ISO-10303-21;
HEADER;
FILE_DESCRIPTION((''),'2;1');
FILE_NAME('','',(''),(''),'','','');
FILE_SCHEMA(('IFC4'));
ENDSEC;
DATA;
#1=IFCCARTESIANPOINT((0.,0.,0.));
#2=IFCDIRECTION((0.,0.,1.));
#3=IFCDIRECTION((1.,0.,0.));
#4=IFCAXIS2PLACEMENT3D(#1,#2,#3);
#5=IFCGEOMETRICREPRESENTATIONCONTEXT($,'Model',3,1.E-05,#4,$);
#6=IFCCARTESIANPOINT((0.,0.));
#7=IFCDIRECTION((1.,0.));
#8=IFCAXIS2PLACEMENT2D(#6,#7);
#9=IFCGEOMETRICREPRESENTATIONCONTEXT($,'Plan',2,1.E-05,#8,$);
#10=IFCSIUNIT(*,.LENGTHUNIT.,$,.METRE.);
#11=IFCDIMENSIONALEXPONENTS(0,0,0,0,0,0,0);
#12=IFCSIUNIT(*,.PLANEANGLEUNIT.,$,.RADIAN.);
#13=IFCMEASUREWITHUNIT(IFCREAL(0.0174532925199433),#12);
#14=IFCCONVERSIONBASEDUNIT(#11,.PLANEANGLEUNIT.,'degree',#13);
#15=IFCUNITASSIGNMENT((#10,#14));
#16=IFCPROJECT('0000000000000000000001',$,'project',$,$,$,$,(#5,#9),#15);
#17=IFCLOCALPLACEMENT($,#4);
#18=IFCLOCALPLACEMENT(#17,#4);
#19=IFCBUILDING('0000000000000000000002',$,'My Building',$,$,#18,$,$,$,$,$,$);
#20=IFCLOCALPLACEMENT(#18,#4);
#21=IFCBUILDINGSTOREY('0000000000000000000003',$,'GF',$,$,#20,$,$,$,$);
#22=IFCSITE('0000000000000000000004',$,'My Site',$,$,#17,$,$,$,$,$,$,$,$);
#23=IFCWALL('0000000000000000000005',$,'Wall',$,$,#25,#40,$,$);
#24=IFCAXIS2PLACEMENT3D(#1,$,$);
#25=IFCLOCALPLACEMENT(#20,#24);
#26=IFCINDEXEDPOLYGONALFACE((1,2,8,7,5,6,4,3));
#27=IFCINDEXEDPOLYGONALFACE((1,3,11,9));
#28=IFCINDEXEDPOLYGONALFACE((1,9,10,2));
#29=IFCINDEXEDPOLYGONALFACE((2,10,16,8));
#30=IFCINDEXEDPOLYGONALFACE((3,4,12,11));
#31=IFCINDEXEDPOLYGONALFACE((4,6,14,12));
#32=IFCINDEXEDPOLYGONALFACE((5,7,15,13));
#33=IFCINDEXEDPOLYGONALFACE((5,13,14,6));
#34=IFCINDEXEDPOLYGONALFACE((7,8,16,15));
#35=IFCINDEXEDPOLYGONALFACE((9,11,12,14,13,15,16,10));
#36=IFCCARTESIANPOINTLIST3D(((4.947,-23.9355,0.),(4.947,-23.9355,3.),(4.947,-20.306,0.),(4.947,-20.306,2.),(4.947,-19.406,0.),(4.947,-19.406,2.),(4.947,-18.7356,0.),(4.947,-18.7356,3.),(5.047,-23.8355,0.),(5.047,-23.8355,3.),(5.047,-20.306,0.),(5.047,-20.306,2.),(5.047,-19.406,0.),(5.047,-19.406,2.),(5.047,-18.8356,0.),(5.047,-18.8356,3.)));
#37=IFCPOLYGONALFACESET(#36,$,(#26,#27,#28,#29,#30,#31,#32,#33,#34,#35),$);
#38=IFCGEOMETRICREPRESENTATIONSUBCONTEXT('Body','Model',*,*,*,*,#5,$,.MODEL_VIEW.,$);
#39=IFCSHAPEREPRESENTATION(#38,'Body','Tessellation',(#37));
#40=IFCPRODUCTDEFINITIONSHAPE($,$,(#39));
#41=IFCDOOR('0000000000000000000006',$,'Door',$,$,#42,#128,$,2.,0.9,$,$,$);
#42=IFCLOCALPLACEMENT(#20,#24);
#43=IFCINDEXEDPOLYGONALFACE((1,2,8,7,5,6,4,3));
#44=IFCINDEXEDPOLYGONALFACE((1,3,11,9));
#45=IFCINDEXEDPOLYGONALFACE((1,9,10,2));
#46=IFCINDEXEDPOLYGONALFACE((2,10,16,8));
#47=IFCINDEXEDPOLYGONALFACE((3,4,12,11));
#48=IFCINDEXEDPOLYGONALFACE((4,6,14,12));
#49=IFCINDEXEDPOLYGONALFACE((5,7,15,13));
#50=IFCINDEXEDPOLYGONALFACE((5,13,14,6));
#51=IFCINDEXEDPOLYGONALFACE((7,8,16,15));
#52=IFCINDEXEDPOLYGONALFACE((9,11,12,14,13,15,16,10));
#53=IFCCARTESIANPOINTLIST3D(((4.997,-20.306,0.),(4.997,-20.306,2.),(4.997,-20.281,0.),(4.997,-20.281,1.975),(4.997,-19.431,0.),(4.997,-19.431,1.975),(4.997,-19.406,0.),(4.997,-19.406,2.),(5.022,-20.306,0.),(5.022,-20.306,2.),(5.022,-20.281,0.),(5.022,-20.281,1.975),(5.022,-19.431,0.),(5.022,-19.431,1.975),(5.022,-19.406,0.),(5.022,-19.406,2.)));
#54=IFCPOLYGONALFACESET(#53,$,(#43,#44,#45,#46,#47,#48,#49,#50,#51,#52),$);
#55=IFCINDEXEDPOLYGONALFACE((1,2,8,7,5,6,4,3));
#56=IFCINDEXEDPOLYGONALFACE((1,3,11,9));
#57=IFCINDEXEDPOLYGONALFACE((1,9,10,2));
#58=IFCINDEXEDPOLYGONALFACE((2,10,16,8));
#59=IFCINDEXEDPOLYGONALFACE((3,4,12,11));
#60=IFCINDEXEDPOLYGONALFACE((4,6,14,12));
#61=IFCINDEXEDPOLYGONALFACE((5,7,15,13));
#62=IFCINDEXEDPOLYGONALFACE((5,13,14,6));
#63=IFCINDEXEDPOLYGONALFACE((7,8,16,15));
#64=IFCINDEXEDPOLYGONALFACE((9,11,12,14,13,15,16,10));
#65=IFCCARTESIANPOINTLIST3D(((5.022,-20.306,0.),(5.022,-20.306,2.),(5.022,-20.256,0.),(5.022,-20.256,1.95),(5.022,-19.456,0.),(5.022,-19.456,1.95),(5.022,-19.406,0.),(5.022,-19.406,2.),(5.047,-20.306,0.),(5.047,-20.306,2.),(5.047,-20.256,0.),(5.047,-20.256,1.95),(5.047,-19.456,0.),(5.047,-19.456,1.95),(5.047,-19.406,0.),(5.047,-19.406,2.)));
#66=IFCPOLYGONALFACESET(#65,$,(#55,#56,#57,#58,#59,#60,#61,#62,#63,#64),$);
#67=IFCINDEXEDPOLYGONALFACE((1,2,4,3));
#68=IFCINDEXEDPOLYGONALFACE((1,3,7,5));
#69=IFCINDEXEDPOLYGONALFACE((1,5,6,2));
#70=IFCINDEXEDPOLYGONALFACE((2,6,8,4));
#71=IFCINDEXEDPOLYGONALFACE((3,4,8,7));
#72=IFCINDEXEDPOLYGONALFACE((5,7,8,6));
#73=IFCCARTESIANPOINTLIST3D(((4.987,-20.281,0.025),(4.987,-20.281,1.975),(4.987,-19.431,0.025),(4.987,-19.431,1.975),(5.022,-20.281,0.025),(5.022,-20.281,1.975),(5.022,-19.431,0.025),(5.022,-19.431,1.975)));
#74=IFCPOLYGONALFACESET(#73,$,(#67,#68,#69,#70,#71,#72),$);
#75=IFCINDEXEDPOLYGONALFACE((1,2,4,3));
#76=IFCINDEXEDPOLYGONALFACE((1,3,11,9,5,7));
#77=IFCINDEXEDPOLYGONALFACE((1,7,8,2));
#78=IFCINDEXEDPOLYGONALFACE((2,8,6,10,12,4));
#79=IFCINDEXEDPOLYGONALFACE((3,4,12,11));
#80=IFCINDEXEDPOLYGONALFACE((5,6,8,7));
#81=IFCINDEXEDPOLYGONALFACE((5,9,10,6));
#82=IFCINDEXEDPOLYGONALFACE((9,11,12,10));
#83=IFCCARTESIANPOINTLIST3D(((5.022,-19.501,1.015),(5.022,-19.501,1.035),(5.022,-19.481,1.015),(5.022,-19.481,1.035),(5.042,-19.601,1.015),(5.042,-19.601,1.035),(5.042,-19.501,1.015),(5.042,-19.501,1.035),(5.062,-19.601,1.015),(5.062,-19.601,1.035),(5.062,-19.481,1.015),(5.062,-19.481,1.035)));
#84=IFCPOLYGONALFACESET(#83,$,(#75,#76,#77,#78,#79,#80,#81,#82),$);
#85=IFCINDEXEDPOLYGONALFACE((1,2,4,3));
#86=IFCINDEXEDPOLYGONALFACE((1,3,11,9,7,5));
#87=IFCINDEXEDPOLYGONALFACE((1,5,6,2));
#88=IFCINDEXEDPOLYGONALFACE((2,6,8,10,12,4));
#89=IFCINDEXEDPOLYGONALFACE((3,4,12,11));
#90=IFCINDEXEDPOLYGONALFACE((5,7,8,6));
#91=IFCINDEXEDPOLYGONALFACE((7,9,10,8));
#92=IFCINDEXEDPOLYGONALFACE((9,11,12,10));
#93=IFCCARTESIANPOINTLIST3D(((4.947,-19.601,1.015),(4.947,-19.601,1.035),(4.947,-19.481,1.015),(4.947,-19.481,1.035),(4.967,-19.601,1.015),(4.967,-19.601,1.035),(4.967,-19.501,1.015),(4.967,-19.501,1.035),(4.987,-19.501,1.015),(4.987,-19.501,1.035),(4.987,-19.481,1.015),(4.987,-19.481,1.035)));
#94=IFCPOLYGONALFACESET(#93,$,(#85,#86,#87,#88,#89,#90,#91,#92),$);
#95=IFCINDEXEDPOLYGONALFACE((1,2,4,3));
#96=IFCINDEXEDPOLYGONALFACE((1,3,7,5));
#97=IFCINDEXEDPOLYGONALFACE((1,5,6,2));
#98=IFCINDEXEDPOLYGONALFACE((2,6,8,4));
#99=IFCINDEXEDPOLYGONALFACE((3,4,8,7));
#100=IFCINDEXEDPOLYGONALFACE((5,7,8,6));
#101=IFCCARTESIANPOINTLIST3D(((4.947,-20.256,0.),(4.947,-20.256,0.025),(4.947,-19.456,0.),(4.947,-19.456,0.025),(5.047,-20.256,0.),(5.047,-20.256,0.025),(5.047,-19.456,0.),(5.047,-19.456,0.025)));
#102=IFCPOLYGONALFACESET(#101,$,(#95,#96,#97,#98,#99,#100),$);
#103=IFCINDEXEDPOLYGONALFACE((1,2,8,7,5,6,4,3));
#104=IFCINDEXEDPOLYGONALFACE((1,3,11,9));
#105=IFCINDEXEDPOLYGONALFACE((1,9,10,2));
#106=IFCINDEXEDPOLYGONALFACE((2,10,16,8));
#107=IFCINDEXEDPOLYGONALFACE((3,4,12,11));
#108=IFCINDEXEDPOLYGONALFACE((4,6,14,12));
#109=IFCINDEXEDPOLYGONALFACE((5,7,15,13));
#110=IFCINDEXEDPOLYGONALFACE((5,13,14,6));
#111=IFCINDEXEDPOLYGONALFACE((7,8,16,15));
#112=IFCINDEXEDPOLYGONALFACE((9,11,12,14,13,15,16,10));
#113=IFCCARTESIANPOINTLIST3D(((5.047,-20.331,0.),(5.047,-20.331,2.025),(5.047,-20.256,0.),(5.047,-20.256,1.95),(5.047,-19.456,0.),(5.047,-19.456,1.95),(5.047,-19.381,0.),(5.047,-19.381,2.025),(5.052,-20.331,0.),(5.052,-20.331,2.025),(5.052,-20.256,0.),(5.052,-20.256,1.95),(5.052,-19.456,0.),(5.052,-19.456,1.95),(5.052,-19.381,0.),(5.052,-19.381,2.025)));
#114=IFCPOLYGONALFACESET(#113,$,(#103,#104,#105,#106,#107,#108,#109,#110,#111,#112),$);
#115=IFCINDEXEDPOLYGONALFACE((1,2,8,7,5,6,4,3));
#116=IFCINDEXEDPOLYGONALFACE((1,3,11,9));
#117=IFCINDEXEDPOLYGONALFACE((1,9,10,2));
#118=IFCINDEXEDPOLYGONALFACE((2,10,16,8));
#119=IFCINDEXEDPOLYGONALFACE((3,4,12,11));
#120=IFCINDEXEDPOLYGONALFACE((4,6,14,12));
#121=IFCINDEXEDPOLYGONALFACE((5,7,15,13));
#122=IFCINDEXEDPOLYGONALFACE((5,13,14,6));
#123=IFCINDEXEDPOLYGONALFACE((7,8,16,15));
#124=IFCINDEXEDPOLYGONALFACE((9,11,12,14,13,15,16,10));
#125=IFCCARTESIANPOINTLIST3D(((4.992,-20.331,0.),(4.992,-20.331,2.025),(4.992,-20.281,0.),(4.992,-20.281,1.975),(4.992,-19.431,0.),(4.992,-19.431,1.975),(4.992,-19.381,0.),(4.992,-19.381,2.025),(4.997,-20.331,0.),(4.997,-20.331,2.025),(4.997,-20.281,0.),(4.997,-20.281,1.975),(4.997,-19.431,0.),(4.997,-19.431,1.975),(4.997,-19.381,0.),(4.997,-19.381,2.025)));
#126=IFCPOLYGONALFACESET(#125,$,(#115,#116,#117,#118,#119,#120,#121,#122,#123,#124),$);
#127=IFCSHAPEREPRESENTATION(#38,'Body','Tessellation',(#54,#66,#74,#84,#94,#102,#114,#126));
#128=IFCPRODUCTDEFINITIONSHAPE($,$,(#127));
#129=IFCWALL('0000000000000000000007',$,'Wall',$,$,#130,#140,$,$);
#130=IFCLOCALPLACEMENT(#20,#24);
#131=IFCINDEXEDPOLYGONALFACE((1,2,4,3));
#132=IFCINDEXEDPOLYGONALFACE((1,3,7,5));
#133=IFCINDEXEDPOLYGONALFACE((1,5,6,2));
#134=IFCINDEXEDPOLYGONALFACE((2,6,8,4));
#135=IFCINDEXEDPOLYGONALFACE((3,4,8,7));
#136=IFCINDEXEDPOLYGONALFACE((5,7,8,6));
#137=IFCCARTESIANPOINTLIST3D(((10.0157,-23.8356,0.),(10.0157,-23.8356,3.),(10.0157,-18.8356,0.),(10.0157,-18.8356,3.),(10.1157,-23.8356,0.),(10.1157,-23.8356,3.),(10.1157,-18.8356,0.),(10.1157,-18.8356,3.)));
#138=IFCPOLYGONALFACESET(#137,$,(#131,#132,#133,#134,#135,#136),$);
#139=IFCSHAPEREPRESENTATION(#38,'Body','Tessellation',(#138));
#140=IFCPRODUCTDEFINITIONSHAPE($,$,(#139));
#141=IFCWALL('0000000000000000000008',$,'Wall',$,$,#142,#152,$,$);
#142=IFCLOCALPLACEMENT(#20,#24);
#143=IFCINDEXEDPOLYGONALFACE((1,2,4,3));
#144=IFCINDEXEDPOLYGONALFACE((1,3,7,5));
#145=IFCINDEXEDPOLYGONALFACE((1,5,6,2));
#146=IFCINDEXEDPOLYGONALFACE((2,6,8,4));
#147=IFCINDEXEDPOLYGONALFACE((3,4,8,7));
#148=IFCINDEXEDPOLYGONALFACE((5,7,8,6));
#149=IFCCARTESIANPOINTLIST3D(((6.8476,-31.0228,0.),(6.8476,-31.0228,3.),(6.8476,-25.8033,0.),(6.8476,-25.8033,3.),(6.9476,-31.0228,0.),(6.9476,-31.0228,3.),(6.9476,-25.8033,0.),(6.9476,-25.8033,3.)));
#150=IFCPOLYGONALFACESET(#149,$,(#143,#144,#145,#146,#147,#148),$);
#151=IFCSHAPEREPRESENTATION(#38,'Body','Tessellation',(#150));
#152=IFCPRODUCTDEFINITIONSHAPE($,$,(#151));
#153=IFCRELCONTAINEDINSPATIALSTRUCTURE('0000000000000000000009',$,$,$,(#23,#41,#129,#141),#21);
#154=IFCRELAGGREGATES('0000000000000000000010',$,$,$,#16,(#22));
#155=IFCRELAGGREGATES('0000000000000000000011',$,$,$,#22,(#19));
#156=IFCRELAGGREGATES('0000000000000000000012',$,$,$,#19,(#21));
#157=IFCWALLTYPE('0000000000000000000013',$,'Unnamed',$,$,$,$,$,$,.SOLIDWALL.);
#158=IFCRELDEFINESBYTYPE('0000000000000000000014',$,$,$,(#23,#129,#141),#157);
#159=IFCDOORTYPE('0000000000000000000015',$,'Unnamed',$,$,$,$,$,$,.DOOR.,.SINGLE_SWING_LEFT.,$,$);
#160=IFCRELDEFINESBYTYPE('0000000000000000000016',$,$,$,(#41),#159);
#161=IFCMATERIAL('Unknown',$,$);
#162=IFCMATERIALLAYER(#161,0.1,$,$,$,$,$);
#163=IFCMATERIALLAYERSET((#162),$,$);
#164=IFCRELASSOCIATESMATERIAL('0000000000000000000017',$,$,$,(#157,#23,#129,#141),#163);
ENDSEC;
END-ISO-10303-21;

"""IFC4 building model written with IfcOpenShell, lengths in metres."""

from ifc_helpers import new_model, entity, si_unit, converted_unit, frame, origin_with_axes, origin_2d_with_axis, place, context, subcontext, project, spatial, line, indexed_curve, outline, extrude, shape, source, transform, mapped, material, layer, layer_set, layer_usage, type_object, type_shapes, element, fill, save


model = new_model("IFC4")

# Units and contexts
model_context = context("Model", 3, precision=1e-05, world=origin_with_axes())
plan_context = context("Plan", 2, precision=1e-05, world=origin_2d_with_axis())
body_context_1 = subcontext(model_context, "Body", "Model", "MODEL_VIEW")
body_context_2 = subcontext(plan_context, "Body", "Plan", "PLAN_VIEW")
ifc_project = project(units=[si_unit("LENGTHUNIT", "METRE"), converted_unit("PLANEANGLEUNIT", "degree", entity("IfcReal", 0.0174532925199433), si_unit("PLANEANGLEUNIT", "RADIAN"), dimensions=[0, 0, 0, 0, 0, 0, 0])], contexts=[model_context, plan_context])

# Site, building, storey
site_placement = place(None, origin_with_axes())
site = spatial("IfcSite", under=ifc_project, at=site_placement, Name="My Site")
building_placement = place(site_placement, origin_with_axes())
building = spatial("IfcBuilding", under=site, at=building_placement, Name="My Building")
storey_placement = place(building_placement, origin_with_axes())
storey = spatial("IfcBuildingStorey", under=building, at=storey_placement, Name="GF")

# Shared definitions
ifc_material = material(Name="Unknown")

# Shared definitions
ifc_layer_1 = layer(ifc_material, 0.1)
ifc_layer_set_1 = layer_set([ifc_layer_1])
wall_type = type_object("IfcWallType", Name="Unnamed", PredefinedType="SOLIDWALL", material=ifc_layer_set_1)

# Shared definitions
shared_shape_1 = source(origin_with_axes(), body_context_1, "Body", "SweptSolid", [
    extrude(outline(indexed_curve([(0.0, 0.0), (0.9, 0.0), (0.9, 2.0), (0.0, 2.0)], segments=[line(1, 2, 3, 4, 1)])), frame((0.0, -0.6, 0.0), z_axis=(0.0, -1.0, 0.0), x_axis=(1.0, 0.0, 0.0)), (0.0, 0.0, -1.0), 1.2),
])
door_type = type_object("IfcDoorType", Name="Unnamed", OperationType="SINGLE_SWING_LEFT", PredefinedType="DOOR")
shared_shape_2 = source(origin_with_axes(), body_context_1, "Body", "SweptSolid", [
    extrude(outline(indexed_curve([(0.0, 0.0), (0.0, 2.0), (0.9, 2.0), (0.9, 0.0), (0.875, 0.0), (0.875, 1.975), (0.025, 1.975), (0.025, 0.0)], segments=[line(1, 2, 3, 4, 5, 6, 7, 8, 1)])), frame((0.0, 0.025, 0.0), z_axis=(0.0, -1.0, 0.0), x_axis=(1.0, 0.0, 0.0)), (0.0, 0.0, -1.0), 0.025),
    extrude(outline(indexed_curve([(0.0, 0.0), (0.0, 2.0), (0.9, 2.0), (0.9, 0.0), (0.85, 0.0), (0.85, 1.95), (0.05, 1.95), (0.05, 0.0)], segments=[line(1, 2, 3, 4, 5, 6, 7, 8, 1)])), frame((0.0, 0.0, 0.0), z_axis=(0.0, -1.0, 0.0), x_axis=(1.0, 0.0, 0.0)), (0.0, 0.0, -1.0), 0.025),
    extrude(outline(indexed_curve([(0.0, 0.0), (0.85, 0.0), (0.85, 0.035), (0.0, 0.035)], segments=[line(1, 2, 3, 4, 1)])), frame((0.025, 0.025, 0.025), z_axis=(0.0, 0.0, 1.0), x_axis=(1.0, 0.0, 0.0)), (0.0, 0.0, 1.0), 1.95),
    extrude(outline(indexed_curve([(0.0, 0.0), (0.0, -0.04), (-0.12, -0.04), (-0.12, -0.02), (-0.02, -0.02), (-0.02, 0.0)], segments=[line(1, 2, 3, 4, 5, 6, 1)])), frame((0.825, 0.025, 1.015), z_axis=(0.0, 0.0, 1.0), x_axis=(1.0, 0.0, 0.0)), (0.0, 0.0, 1.0), 0.02),
    extrude(outline(indexed_curve([(0.0, 0.0), (0.0, 0.04), (-0.12, 0.04), (-0.12, 0.02), (-0.02, 0.02), (-0.02, 0.0)], segments=[line(1, 2, 3, 4, 5, 6, 1)])), frame((0.825, 0.06, 1.015), z_axis=(0.0, 0.0, 1.0), x_axis=(1.0, 0.0, 0.0)), (0.0, 0.0, 1.0), 0.02),
    extrude(outline(indexed_curve([(0.0, 0.0), (0.8, 0.0), (0.8, 0.1), (0.0, 0.1)], segments=[line(1, 2, 3, 4, 1)])), frame((0.05, 0.0, 0.0), z_axis=(0.0, 0.0, 1.0), x_axis=(1.0, 0.0, 0.0)), (0.0, 0.0, 1.0), 0.025),
    extrude(outline(indexed_curve([(0.0, 0.0), (0.0, 2.025), (0.95, 2.025), (0.95, 0.0), (0.875, 0.0), (0.875, 1.95), (0.075, 1.95), (0.075, 0.0)], segments=[line(1, 2, 3, 4, 5, 6, 7, 8, 1)])), frame((-0.025, -0.005, 0.0), z_axis=(0.0, -1.0, 0.0), x_axis=(1.0, 0.0, 0.0)), (0.0, 0.0, -1.0), 0.005),
    extrude(outline(indexed_curve([(0.0, 0.0), (0.0, 2.025), (0.95, 2.025), (0.95, 0.0), (0.9, 0.0), (0.9, 1.975), (0.05, 1.975), (0.05, 0.0)], segments=[line(1, 2, 3, 4, 5, 6, 7, 8, 1)])), frame((-0.025, 0.05, 0.0), z_axis=(0.0, -1.0, 0.0), x_axis=(1.0, 0.0, 0.0)), (0.0, 0.0, -1.0), 0.005),
])
shared_shape_3 = source(origin_with_axes(), body_context_2, "Body", "Curve2D", [
    entity("IfcIndexedPolyCurve", entity("IfcCartesianPointList2D", [[0.0, 0.0], [0.0, 0.05], [0.025, 0.05], [0.025, 0.025], [0.05, 0.025], [0.05, 0.0]]), [entity("IfcLineIndex", [1, 2, 3, 4, 5, 6, 1])]),
    entity("IfcIndexedPolyCurve", entity("IfcCartesianPointList2D", [[0.9, 0.0], [0.9, 0.05], [0.875, 0.05], [0.875, 0.025], [0.85, 0.025], [0.85, 0.0]]), [entity("IfcLineIndex", [1, 2, 3, 4, 5, 6, 1])]),
    entity("IfcTrimmedCurve", entity("IfcEllipse", entity("IfcAxis2Placement2D", entity("IfcCartesianPoint", [0.06, 0.05]), entity("IfcDirection", [1.0, 0.0])), 0.815, 0.85), [entity("IfcCartesianPoint", [0.875, 0.05])], [entity("IfcCartesianPoint", [0.06, 0.9])], True, "CARTESIAN"),
    entity("IfcIndexedPolyCurve", entity("IfcCartesianPointList2D", [[0.025, 0.05], [0.06, 0.05], [0.06, 0.9], [0.025, 0.9]]), [entity("IfcLineIndex", [1, 2, 3, 4, 1])]),
])
type_shapes(door_type, [shared_shape_2, shared_shape_3])

# Wall, opening, door
ifc_layer_usage_1 = layer_usage(ifc_layer_set_1, "AXIS2", "POSITIVE", 0.0)
wall_1_placement = place(storey_placement, frame((5.047, -23.8355, 0.0), z_axis=(0.0, 0.0, 1.0), x_axis=(0.0, 1.0, 0.0)))
wall_1 = element("IfcWall", 1, at=wall_1_placement, inside=storey, type_object=wall_type, material=ifc_layer_usage_1, Name="Wall", context=body_context_1, shape_type="SweptSolid", body=[
    extrude(outline(indexed_curve([(0.0, 0.0), (-0.1, 0.1), (5.1, 0.1), (5.0, 0.0)], segments=[line(1, 2, 3, 4, 1)])), origin_with_axes(), (0.0, 0.0, 1.0), 3.0),
])
opening_1_placement = place(wall_1_placement, frame((3.5295, 0.0, 0.0), z_axis=(0.0, 0.0, 1.0), x_axis=(1.0, 0.0, 0.0)))
opening_1 = element("IfcOpeningElement", 2, at=opening_1_placement, cuts=wall_1, PredefinedType="OPENING", context=body_context_1, shape_type="MappedRepresentation", body=[
    mapped(shared_shape_1, transform((0.0, 0.0, 0.0), x_axis=(1.0, 0.0, 0.0), y_axis=(0.0, 1.0, 0.0), z_axis=(0.0, 0.0, 1.0), scale=1.0)),
])
door_1_placement = place(opening_1_placement, frame((0.0, 0.0, 0.0), z_axis=(0.0, 0.0, 1.0), x_axis=(1.0, 0.0, 0.0)))
door_1 = element("IfcDoor", 3, at=door_1_placement, inside=storey, type_object=door_type, Name="Door", OverallHeight=2.0, OverallWidth=0.9, shapes=[
    shape(body_context_1, "Body", "MappedRepresentation", [mapped(shared_shape_2, transform((0.0, 0.0, 0.0), x_axis=(1.0, 0.0, 0.0), y_axis=(0.0, 1.0, 0.0), z_axis=(0.0, 0.0, 1.0), scale=1.0))]),
    shape(body_context_2, "Body", "MappedRepresentation", [mapped(shared_shape_3, transform((0.0, 0.0, 0.0), x_axis=(1.0, 0.0, 0.0), y_axis=(0.0, 1.0, 0.0), z_axis=(0.0, 0.0, 1.0), scale=1.0))]),
])
fill(opening_1, door_1)

# Walls
ifc_layer_usage_2 = layer_usage(ifc_layer_set_1, "AXIS2", "POSITIVE", 0.0)
wall_2_placement = place(storey_placement, frame((10.0157, -18.8356, 0.0), z_axis=(0.0, 0.0, 1.0), x_axis=(0.0, -1.0, 0.0)))
element("IfcWall", 4, at=wall_2_placement, inside=storey, type_object=wall_type, material=ifc_layer_usage_2, Name="Wall", context=body_context_1, shape_type="SweptSolid", body=[
    extrude(outline(indexed_curve([(0.0, 0.0), (0.0, 0.1), (5.0, 0.1), (5.0, 0.0)], segments=[line(1, 2, 3, 4, 1)])), origin_with_axes(), (0.0, 0.0, 1.0), 3.0),
])
ifc_layer_usage_3 = layer_usage(ifc_layer_set_1, "AXIS2", "POSITIVE", 0.0)
wall_3_placement = place(storey_placement, frame((6.8476, -25.8033, 0.0), z_axis=(0.0, 0.0, 1.0), x_axis=(0.0, -1.0, 0.0)))
element("IfcWall", 5, at=wall_3_placement, inside=storey, type_object=wall_type, material=ifc_layer_usage_3, Name="Wall", context=body_context_1, shape_type="SweptSolid", body=[
    extrude(outline(indexed_curve([(0.0, 0.0), (0.0, 0.1), (5.2195, 0.1), (5.2195, 0.0)], segments=[line(1, 2, 3, 4, 1)])), origin_with_axes(), (0.0, 0.0, 1.0), 3.0),
])

save(model, "model.ifc")
